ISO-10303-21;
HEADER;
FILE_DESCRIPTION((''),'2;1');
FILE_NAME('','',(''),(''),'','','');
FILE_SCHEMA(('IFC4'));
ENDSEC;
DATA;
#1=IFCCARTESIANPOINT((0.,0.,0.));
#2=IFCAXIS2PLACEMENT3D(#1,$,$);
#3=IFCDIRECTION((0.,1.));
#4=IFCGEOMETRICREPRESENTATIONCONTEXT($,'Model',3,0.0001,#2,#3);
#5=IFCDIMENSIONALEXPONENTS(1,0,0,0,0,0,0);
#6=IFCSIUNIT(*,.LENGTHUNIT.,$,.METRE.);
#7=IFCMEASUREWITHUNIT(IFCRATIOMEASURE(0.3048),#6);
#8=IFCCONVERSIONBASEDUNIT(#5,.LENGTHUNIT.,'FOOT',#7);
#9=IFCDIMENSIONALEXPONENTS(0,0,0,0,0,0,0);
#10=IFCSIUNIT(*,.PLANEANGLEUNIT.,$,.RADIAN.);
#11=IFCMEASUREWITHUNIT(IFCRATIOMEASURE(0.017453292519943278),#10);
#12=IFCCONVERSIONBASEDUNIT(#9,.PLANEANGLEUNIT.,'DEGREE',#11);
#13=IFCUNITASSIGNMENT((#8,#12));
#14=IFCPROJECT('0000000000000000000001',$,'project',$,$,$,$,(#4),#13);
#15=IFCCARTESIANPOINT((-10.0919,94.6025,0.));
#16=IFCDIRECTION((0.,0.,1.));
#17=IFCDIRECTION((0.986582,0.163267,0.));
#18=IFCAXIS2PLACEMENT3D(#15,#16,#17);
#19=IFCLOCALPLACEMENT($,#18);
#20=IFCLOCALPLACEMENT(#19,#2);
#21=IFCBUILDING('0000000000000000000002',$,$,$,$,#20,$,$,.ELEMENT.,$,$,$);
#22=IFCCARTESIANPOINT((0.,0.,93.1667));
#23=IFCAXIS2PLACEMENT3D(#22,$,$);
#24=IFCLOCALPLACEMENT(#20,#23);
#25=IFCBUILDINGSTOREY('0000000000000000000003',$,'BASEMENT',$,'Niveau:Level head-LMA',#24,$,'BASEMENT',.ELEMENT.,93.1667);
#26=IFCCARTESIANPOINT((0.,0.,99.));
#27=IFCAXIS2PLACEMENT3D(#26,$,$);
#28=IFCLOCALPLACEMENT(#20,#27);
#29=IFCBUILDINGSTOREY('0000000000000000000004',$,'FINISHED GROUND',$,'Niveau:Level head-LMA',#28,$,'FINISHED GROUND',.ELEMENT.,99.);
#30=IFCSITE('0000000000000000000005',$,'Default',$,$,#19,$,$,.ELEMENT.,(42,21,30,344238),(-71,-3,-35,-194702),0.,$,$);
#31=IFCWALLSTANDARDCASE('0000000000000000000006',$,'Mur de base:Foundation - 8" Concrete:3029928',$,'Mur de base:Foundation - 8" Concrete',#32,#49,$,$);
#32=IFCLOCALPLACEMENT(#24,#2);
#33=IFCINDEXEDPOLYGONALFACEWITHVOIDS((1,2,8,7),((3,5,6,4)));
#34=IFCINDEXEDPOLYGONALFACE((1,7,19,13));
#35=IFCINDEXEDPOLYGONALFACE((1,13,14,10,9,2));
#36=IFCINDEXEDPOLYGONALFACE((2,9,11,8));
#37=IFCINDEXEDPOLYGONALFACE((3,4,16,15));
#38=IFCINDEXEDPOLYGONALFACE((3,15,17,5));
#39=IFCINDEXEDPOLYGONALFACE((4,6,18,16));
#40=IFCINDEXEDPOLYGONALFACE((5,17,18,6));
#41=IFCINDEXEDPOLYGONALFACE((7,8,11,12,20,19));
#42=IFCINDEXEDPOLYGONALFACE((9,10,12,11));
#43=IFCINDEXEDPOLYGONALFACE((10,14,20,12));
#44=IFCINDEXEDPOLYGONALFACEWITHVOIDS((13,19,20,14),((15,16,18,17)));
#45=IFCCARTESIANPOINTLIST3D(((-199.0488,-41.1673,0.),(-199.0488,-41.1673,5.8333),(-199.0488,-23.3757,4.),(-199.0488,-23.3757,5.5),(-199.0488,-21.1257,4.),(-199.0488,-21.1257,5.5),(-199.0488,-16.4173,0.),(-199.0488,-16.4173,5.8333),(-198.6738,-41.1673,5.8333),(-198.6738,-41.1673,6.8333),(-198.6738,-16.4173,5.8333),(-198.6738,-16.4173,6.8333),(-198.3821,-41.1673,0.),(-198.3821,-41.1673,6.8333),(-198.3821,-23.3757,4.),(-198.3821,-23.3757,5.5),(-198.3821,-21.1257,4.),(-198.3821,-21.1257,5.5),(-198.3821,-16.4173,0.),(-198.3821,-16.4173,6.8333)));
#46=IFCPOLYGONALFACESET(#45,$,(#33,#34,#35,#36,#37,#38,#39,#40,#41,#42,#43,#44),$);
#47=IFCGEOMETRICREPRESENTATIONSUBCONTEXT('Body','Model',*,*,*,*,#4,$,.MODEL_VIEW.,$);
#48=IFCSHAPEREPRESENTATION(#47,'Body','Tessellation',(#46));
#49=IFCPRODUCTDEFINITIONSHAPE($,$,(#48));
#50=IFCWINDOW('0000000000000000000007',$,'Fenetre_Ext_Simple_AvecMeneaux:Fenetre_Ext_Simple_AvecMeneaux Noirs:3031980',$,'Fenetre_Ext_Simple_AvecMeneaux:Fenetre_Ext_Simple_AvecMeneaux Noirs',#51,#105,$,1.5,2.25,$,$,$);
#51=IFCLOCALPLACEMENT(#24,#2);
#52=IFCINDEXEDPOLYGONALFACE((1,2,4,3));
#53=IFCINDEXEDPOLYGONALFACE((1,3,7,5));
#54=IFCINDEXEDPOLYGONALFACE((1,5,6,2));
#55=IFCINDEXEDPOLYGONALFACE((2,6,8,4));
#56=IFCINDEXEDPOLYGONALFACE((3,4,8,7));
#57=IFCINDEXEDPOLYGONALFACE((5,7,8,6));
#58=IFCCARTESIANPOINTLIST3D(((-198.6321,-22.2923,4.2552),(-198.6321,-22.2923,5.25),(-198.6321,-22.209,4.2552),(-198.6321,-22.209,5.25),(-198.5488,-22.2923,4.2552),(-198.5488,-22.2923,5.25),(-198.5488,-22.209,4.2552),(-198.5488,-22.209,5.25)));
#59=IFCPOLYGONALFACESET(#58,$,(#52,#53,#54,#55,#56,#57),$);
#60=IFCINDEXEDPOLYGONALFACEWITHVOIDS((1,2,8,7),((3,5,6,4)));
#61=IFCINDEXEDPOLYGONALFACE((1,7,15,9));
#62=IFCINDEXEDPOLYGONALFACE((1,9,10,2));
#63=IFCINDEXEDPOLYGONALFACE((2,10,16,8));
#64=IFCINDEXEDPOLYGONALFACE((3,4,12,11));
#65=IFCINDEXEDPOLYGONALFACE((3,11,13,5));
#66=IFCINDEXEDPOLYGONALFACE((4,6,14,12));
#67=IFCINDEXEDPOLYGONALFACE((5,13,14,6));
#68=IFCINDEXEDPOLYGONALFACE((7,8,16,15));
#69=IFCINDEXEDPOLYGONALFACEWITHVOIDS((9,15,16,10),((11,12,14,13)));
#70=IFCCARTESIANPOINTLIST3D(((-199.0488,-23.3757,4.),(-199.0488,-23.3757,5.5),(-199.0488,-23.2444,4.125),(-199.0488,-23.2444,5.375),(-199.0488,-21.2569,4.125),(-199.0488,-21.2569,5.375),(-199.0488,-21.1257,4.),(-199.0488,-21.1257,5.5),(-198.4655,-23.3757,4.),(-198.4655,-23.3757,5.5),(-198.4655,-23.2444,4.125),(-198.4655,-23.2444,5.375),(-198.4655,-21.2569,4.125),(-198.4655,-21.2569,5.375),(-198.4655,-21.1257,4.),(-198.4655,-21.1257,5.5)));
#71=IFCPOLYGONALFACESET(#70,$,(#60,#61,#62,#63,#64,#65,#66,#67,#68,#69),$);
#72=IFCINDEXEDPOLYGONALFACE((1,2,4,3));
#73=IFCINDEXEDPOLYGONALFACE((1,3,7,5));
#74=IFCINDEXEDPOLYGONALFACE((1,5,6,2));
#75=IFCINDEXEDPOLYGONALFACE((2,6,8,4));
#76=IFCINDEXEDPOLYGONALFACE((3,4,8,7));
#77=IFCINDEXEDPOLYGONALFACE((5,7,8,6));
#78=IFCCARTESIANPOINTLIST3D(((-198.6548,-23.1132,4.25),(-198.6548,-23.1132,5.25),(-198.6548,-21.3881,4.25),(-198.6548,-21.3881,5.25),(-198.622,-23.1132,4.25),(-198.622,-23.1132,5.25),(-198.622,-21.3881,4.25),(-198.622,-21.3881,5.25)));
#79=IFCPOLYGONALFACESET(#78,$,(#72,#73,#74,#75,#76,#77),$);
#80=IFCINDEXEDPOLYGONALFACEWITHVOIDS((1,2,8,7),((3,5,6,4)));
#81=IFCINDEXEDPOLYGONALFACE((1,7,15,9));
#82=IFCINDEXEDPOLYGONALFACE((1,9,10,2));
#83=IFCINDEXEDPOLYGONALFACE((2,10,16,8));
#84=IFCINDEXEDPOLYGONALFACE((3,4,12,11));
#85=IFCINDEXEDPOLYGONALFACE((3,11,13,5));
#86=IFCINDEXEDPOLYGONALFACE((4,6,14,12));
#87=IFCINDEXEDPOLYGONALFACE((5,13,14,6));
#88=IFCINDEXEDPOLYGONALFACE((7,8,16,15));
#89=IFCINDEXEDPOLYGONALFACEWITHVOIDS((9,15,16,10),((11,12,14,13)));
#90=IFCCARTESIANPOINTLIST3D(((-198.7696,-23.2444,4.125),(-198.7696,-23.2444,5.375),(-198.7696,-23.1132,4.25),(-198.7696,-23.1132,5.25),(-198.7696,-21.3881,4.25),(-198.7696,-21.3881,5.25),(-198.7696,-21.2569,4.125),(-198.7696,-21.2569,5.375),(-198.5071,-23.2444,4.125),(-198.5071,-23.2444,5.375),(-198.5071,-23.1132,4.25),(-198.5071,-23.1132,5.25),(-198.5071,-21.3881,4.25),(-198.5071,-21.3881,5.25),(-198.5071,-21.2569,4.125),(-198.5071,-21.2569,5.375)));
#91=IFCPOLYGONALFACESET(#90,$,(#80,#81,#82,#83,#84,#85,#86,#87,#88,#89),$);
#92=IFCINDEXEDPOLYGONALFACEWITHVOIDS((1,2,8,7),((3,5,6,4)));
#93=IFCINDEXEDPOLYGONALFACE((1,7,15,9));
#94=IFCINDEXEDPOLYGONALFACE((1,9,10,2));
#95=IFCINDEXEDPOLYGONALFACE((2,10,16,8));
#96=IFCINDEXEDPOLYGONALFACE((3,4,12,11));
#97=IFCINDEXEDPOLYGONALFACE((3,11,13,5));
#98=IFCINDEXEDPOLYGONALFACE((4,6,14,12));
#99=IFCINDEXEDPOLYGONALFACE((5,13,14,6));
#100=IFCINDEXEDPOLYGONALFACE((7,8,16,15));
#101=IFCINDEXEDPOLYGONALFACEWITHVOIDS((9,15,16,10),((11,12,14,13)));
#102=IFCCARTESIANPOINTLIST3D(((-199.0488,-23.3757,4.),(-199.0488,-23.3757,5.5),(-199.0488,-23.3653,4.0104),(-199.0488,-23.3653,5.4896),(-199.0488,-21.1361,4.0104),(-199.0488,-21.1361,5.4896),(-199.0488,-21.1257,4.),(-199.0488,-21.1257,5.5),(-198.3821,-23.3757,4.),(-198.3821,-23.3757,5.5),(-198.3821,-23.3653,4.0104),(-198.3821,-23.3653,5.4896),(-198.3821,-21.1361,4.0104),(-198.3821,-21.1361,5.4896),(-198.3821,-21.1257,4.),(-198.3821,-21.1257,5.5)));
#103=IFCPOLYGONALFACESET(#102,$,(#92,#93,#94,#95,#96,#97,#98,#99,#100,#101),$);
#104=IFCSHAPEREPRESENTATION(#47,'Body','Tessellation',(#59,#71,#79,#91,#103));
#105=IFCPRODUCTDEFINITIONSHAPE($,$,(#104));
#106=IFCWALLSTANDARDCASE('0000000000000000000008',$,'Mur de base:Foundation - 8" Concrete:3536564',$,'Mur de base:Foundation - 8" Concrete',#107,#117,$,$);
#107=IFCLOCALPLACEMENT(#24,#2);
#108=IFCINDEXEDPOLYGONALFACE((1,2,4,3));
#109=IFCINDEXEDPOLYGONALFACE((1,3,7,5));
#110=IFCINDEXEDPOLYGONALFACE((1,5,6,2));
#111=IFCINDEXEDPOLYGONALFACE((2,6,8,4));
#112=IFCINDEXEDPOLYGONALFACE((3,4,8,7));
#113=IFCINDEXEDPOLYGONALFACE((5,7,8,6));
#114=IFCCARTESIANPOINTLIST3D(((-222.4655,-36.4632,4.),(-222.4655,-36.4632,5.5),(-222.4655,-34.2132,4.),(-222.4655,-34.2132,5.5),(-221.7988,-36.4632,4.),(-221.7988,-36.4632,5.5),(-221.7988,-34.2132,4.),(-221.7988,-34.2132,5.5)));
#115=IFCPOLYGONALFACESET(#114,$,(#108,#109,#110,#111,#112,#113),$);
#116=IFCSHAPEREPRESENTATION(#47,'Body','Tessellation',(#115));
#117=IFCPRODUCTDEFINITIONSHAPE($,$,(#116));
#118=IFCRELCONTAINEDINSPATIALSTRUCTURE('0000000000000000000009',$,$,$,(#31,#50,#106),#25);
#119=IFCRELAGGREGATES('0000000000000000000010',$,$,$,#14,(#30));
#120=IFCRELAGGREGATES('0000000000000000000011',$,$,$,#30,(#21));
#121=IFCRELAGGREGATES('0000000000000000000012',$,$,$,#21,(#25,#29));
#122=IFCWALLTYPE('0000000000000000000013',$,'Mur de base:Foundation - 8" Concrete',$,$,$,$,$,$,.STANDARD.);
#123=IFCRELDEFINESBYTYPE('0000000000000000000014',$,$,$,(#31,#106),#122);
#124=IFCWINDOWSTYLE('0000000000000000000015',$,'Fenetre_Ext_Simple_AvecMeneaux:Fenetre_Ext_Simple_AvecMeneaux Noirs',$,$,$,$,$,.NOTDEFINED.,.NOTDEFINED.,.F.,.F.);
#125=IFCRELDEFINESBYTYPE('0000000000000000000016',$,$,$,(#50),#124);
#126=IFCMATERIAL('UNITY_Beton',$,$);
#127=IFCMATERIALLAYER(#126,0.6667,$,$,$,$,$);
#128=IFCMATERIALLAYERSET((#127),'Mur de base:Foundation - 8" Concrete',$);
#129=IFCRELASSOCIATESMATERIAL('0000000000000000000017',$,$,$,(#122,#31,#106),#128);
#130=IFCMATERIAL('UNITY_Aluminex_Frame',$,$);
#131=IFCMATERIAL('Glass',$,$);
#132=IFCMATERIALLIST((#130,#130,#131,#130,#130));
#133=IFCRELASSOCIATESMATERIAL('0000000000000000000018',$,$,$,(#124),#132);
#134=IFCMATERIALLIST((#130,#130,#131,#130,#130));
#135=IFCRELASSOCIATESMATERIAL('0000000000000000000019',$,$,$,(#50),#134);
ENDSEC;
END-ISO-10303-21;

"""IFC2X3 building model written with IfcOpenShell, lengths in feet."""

from ifc_helpers import new_model, entity, si_unit, converted_unit, direction, frame, frame_2d, origin, place, context, subcontext, project, spatial, polyline, rectangle, outline, extrude, clip, bounded_halfspace, source, transform, mapped, material, material_list, layer, layer_set, layer_usage, type_object, type_shapes, element, fill, save


model = new_model("IFC2X3")

# Units and contexts
model_context = context("Model", 3, precision=0.0001, world=origin(), true_north=direction((0.0, 1.0)))
body_context = subcontext(model_context, "Body", "Model", "MODEL_VIEW")
ifc_project = project(units=[converted_unit("LENGTHUNIT", "FOOT", entity("IfcRatioMeasure", 0.3048), si_unit("LENGTHUNIT", "METRE"), dimensions=[1, 0, 0, 0, 0, 0, 0]), converted_unit("PLANEANGLEUNIT", "DEGREE", entity("IfcRatioMeasure", 0.017453292519943278), si_unit("PLANEANGLEUNIT", "RADIAN"), dimensions=[0, 0, 0, 0, 0, 0, 0])], contexts=[model_context])

# Site, building, storey
site_placement = place(None, frame((-10.0919, 94.6025, 0.0), z_axis=(0.0, 0.0, 1.0), x_axis=(0.986582, 0.163267, 0.0)))
site = spatial("IfcSite", under=ifc_project, at=site_placement, Name="Default", CompositionType="ELEMENT", RefLatitude=(42, 21, 30, 344238), RefLongitude=(-71, -3, -35, -194702), RefElevation=0.0)
building_placement = place(site_placement, origin())
building = spatial("IfcBuilding", under=site, at=building_placement, CompositionType="ELEMENT")
storey_1_placement = place(building_placement, frame((0.0, 0.0, 93.1667)))
storey_1 = spatial("IfcBuildingStorey", under=building, at=storey_1_placement, Name="BASEMENT", ObjectType="Niveau:Level head-LMA", LongName="BASEMENT", CompositionType="ELEMENT", Elevation=93.1667)

# Shared definitions
ifc_material_1 = material(Name="UNITY_Beton")
ifc_layer_1 = layer(ifc_material_1, 0.6667)
ifc_layer_set_1 = layer_set([ifc_layer_1], Name="Mur de base:Foundation - 8\" Concrete")
wall_type = type_object("IfcWallType", Name="Mur de base:Foundation - 8\" Concrete", PredefinedType="STANDARD", material=ifc_layer_set_1)
ifc_material_2 = material(Name="UNITY_Aluminex_Frame")
ifc_material_3 = material(Name="Glass")
ifc_material_list_1 = material_list([ifc_material_2, ifc_material_2, ifc_material_3, ifc_material_2, ifc_material_2])
window_style_1 = type_object("IfcWindowStyle", Name="Fenetre_Ext_Simple_AvecMeneaux:Fenetre_Ext_Simple_AvecMeneaux Noirs", ConstructionType="NOTDEFINED", OperationType="NOTDEFINED", ParameterTakesPrecedence=False, Sizeable=False, material=ifc_material_list_1)
shared_shape_1 = source(origin(), body_context, "Body", "SweptSolid", [
    extrude(rectangle(XDim=0.0833, YDim=0.0833, at=frame_2d((0.0, 0.0), x_axis=(1.0, 0.0))), frame((1.125, 0.4583, 0.2552), z_axis=(0.0, 0.0, 1.0), x_axis=(0.0, -1.0, 0.0)), (0.0, 0.0, 1.0), 0.9948),
    extrude(outline(polyline([(-0.75, -1.125), (0.75, -1.125), (0.75, 1.125), (-0.75, 1.125), (-0.75, -1.125)]), holes=[polyline([(-0.625, 0.9938), (0.625, 0.9938), (0.625, -0.9938), (-0.625, -0.9938), (-0.625, 0.9938)])]), frame((1.125, 0.0, 0.75), z_axis=(0.0, 1.0, 0.0), x_axis=(0.0, 0.0, -1.0)), (0.0, 0.0, 1.0), 0.5833),
    extrude(rectangle(XDim=0.0328, YDim=1.7251, at=frame_2d((0.0, 0.0), x_axis=(1.0, 0.0))), frame((1.125, 0.4104, 0.25), z_axis=(0.0, 0.0, 1.0), x_axis=(0.0, 1.0, 0.0)), (0.0, 0.0, 1.0), 1.0),
    extrude(outline(polyline([(-0.9938, -0.625), (0.9938, -0.625), (0.9938, 0.625), (-0.9938, 0.625), (-0.9938, -0.625)]), holes=[polyline([(-0.8625, -0.5), (-0.8625, 0.5), (0.8625, 0.5), (0.8625, -0.5), (-0.8625, -0.5)])]), frame((1.125, 0.2792, 0.75), z_axis=(0.0, 1.0, 0.0), x_axis=(1.0, 0.0, 0.0)), (0.0, 0.0, 1.0), 0.2625),
    extrude(outline(polyline([(-1.125, -0.75), (1.125, -0.75), (1.125, 0.75), (-1.125, 0.75), (-1.125, -0.75)]), holes=[polyline([(1.1146, -0.7396), (-1.1146, -0.7396), (-1.1146, 0.7396), (1.1146, 0.7396), (1.1146, -0.7396)])]), frame((1.125, 0.0, 0.75), z_axis=(0.0, 1.0, 0.0), x_axis=(1.0, 0.0, 0.0)), (0.0, 0.0, 1.0), 0.6667),
])
type_shapes(window_style_1, [shared_shape_1])

# Shared definitions
storey_2_placement = place(building_placement, frame((0.0, 0.0, 99.0)))
storey_2 = spatial("IfcBuildingStorey", under=building, at=storey_2_placement, Name="FINISHED GROUND", ObjectType="Niveau:Level head-LMA", LongName="FINISHED GROUND", CompositionType="ELEMENT", Elevation=99.0)

# Wall, opening, window
ifc_layer_usage_1 = layer_usage(ifc_layer_set_1, "AXIS2", "POSITIVE", -0.3333)
wall_1_placement = place(storey_1_placement, frame((-198.7155, -41.1673, 0.0), z_axis=(0.0, 0.0, 1.0), x_axis=(0.0, 1.0, 0.0)))
wall_1 = element("IfcWallStandardCase", 1, at=wall_1_placement, inside=storey_1, type_object=wall_type, material=ifc_layer_usage_1, Name="Mur de base:Foundation - 8\" Concrete:3029928", ObjectType="Mur de base:Foundation - 8\" Concrete", context=body_context, shape_type="Clipping", body=[
    clip(clip(extrude(rectangle(XDim=24.75, YDim=0.6667, at=frame_2d((12.375, 0.0), x_axis=(-1.0, 0.0))), origin(), (0.0, 0.0, 1.0), 6.8333), bounded_halfspace(frame((0.0, -0.0416, 5.8333), z_axis=(0.0, 0.0, -1.0), x_axis=(-1.0, 0.0, 0.0)), True, frame((0.0, -0.0416, 5.8333), z_axis=(0.0, 0.0, -1.0), x_axis=(-1.0, 0.0, 0.0)), polyline([(0.0, 0.0), (0.0, 0.375), (-24.75, 0.375), (-24.75, 0.0), (0.0, 0.0)]))), bounded_halfspace(frame((24.75, -0.0416, 5.8333), z_axis=(0.0, -1.0, 0.0), x_axis=(0.0, 0.0, 1.0)), True, frame((24.75, -0.0416, 5.8333), z_axis=(0.0, -1.0, 0.0), x_axis=(0.0, 0.0, 1.0)), polyline([(0.0, 0.0), (1.0, 0.0), (1.0, 24.75), (0.0, 24.75), (0.0, 0.0)]))),
])
opening_1_placement = place(wall_1_placement, frame((20.0417, 0.3333, 4.0)))
opening_1 = element("IfcOpeningElement", 2, at=opening_1_placement, cuts=wall_1, ObjectType="Opening", context=body_context, shape_type="SweptSolid", body=[
    extrude(rectangle(XDim=1.5, YDim=2.25, at=frame_2d((0.75, 1.125), x_axis=(1.0, 0.0))), frame((0.0, 0.0, 0.0), z_axis=(0.0, -1.0, 0.0), x_axis=(0.0, 0.0, 1.0)), (0.0, 0.0, 1.0), 0.6667),
])
ifc_material_list_2 = material_list([ifc_material_2, ifc_material_2, ifc_material_3, ifc_material_2, ifc_material_2])
window_1_placement = place(opening_1_placement, frame((0.0, 0.0, 0.0), z_axis=(0.0, 0.0, 1.0), x_axis=(-1.0, 0.0, 0.0)))
window_1 = element("IfcWindow", 3, at=window_1_placement, inside=storey_1, type_object=window_style_1, material=ifc_material_list_2, Name="Fenetre_Ext_Simple_AvecMeneaux:Fenetre_Ext_Simple_AvecMeneaux Noirs:3031980", ObjectType="Fenetre_Ext_Simple_AvecMeneaux:Fenetre_Ext_Simple_AvecMeneaux Noirs", OverallHeight=1.5, OverallWidth=2.25, context=body_context, shape_type="MappedRepresentation", body=[
    mapped(shared_shape_1, transform((0.0, 0.0, 0.0), scale=1.0)),
])
fill(opening_1, window_1)

# Wall
ifc_layer_usage_2 = layer_usage(ifc_layer_set_1, "AXIS2", "NEGATIVE", 0.3333)
wall_2_placement = place(storey_1_placement, frame((-222.1321, -36.4632, 4.0), z_axis=(0.0, 0.0, 1.0), x_axis=(0.0, 1.0, 0.0)))
element("IfcWallStandardCase", 4, at=wall_2_placement, inside=storey_1, type_object=wall_type, material=ifc_layer_usage_2, Name="Mur de base:Foundation - 8\" Concrete:3536564", ObjectType="Mur de base:Foundation - 8\" Concrete", context=body_context, shape_type="SweptSolid", body=[
    extrude(rectangle(XDim=2.25, YDim=0.6667, at=frame_2d((0.0, 0.0), x_axis=(1.0, 0.0))), frame((1.125, 0.0, 0.0)), (0.0, 0.0, 1.0), 1.5),
])

save(model, "model.ifc")
